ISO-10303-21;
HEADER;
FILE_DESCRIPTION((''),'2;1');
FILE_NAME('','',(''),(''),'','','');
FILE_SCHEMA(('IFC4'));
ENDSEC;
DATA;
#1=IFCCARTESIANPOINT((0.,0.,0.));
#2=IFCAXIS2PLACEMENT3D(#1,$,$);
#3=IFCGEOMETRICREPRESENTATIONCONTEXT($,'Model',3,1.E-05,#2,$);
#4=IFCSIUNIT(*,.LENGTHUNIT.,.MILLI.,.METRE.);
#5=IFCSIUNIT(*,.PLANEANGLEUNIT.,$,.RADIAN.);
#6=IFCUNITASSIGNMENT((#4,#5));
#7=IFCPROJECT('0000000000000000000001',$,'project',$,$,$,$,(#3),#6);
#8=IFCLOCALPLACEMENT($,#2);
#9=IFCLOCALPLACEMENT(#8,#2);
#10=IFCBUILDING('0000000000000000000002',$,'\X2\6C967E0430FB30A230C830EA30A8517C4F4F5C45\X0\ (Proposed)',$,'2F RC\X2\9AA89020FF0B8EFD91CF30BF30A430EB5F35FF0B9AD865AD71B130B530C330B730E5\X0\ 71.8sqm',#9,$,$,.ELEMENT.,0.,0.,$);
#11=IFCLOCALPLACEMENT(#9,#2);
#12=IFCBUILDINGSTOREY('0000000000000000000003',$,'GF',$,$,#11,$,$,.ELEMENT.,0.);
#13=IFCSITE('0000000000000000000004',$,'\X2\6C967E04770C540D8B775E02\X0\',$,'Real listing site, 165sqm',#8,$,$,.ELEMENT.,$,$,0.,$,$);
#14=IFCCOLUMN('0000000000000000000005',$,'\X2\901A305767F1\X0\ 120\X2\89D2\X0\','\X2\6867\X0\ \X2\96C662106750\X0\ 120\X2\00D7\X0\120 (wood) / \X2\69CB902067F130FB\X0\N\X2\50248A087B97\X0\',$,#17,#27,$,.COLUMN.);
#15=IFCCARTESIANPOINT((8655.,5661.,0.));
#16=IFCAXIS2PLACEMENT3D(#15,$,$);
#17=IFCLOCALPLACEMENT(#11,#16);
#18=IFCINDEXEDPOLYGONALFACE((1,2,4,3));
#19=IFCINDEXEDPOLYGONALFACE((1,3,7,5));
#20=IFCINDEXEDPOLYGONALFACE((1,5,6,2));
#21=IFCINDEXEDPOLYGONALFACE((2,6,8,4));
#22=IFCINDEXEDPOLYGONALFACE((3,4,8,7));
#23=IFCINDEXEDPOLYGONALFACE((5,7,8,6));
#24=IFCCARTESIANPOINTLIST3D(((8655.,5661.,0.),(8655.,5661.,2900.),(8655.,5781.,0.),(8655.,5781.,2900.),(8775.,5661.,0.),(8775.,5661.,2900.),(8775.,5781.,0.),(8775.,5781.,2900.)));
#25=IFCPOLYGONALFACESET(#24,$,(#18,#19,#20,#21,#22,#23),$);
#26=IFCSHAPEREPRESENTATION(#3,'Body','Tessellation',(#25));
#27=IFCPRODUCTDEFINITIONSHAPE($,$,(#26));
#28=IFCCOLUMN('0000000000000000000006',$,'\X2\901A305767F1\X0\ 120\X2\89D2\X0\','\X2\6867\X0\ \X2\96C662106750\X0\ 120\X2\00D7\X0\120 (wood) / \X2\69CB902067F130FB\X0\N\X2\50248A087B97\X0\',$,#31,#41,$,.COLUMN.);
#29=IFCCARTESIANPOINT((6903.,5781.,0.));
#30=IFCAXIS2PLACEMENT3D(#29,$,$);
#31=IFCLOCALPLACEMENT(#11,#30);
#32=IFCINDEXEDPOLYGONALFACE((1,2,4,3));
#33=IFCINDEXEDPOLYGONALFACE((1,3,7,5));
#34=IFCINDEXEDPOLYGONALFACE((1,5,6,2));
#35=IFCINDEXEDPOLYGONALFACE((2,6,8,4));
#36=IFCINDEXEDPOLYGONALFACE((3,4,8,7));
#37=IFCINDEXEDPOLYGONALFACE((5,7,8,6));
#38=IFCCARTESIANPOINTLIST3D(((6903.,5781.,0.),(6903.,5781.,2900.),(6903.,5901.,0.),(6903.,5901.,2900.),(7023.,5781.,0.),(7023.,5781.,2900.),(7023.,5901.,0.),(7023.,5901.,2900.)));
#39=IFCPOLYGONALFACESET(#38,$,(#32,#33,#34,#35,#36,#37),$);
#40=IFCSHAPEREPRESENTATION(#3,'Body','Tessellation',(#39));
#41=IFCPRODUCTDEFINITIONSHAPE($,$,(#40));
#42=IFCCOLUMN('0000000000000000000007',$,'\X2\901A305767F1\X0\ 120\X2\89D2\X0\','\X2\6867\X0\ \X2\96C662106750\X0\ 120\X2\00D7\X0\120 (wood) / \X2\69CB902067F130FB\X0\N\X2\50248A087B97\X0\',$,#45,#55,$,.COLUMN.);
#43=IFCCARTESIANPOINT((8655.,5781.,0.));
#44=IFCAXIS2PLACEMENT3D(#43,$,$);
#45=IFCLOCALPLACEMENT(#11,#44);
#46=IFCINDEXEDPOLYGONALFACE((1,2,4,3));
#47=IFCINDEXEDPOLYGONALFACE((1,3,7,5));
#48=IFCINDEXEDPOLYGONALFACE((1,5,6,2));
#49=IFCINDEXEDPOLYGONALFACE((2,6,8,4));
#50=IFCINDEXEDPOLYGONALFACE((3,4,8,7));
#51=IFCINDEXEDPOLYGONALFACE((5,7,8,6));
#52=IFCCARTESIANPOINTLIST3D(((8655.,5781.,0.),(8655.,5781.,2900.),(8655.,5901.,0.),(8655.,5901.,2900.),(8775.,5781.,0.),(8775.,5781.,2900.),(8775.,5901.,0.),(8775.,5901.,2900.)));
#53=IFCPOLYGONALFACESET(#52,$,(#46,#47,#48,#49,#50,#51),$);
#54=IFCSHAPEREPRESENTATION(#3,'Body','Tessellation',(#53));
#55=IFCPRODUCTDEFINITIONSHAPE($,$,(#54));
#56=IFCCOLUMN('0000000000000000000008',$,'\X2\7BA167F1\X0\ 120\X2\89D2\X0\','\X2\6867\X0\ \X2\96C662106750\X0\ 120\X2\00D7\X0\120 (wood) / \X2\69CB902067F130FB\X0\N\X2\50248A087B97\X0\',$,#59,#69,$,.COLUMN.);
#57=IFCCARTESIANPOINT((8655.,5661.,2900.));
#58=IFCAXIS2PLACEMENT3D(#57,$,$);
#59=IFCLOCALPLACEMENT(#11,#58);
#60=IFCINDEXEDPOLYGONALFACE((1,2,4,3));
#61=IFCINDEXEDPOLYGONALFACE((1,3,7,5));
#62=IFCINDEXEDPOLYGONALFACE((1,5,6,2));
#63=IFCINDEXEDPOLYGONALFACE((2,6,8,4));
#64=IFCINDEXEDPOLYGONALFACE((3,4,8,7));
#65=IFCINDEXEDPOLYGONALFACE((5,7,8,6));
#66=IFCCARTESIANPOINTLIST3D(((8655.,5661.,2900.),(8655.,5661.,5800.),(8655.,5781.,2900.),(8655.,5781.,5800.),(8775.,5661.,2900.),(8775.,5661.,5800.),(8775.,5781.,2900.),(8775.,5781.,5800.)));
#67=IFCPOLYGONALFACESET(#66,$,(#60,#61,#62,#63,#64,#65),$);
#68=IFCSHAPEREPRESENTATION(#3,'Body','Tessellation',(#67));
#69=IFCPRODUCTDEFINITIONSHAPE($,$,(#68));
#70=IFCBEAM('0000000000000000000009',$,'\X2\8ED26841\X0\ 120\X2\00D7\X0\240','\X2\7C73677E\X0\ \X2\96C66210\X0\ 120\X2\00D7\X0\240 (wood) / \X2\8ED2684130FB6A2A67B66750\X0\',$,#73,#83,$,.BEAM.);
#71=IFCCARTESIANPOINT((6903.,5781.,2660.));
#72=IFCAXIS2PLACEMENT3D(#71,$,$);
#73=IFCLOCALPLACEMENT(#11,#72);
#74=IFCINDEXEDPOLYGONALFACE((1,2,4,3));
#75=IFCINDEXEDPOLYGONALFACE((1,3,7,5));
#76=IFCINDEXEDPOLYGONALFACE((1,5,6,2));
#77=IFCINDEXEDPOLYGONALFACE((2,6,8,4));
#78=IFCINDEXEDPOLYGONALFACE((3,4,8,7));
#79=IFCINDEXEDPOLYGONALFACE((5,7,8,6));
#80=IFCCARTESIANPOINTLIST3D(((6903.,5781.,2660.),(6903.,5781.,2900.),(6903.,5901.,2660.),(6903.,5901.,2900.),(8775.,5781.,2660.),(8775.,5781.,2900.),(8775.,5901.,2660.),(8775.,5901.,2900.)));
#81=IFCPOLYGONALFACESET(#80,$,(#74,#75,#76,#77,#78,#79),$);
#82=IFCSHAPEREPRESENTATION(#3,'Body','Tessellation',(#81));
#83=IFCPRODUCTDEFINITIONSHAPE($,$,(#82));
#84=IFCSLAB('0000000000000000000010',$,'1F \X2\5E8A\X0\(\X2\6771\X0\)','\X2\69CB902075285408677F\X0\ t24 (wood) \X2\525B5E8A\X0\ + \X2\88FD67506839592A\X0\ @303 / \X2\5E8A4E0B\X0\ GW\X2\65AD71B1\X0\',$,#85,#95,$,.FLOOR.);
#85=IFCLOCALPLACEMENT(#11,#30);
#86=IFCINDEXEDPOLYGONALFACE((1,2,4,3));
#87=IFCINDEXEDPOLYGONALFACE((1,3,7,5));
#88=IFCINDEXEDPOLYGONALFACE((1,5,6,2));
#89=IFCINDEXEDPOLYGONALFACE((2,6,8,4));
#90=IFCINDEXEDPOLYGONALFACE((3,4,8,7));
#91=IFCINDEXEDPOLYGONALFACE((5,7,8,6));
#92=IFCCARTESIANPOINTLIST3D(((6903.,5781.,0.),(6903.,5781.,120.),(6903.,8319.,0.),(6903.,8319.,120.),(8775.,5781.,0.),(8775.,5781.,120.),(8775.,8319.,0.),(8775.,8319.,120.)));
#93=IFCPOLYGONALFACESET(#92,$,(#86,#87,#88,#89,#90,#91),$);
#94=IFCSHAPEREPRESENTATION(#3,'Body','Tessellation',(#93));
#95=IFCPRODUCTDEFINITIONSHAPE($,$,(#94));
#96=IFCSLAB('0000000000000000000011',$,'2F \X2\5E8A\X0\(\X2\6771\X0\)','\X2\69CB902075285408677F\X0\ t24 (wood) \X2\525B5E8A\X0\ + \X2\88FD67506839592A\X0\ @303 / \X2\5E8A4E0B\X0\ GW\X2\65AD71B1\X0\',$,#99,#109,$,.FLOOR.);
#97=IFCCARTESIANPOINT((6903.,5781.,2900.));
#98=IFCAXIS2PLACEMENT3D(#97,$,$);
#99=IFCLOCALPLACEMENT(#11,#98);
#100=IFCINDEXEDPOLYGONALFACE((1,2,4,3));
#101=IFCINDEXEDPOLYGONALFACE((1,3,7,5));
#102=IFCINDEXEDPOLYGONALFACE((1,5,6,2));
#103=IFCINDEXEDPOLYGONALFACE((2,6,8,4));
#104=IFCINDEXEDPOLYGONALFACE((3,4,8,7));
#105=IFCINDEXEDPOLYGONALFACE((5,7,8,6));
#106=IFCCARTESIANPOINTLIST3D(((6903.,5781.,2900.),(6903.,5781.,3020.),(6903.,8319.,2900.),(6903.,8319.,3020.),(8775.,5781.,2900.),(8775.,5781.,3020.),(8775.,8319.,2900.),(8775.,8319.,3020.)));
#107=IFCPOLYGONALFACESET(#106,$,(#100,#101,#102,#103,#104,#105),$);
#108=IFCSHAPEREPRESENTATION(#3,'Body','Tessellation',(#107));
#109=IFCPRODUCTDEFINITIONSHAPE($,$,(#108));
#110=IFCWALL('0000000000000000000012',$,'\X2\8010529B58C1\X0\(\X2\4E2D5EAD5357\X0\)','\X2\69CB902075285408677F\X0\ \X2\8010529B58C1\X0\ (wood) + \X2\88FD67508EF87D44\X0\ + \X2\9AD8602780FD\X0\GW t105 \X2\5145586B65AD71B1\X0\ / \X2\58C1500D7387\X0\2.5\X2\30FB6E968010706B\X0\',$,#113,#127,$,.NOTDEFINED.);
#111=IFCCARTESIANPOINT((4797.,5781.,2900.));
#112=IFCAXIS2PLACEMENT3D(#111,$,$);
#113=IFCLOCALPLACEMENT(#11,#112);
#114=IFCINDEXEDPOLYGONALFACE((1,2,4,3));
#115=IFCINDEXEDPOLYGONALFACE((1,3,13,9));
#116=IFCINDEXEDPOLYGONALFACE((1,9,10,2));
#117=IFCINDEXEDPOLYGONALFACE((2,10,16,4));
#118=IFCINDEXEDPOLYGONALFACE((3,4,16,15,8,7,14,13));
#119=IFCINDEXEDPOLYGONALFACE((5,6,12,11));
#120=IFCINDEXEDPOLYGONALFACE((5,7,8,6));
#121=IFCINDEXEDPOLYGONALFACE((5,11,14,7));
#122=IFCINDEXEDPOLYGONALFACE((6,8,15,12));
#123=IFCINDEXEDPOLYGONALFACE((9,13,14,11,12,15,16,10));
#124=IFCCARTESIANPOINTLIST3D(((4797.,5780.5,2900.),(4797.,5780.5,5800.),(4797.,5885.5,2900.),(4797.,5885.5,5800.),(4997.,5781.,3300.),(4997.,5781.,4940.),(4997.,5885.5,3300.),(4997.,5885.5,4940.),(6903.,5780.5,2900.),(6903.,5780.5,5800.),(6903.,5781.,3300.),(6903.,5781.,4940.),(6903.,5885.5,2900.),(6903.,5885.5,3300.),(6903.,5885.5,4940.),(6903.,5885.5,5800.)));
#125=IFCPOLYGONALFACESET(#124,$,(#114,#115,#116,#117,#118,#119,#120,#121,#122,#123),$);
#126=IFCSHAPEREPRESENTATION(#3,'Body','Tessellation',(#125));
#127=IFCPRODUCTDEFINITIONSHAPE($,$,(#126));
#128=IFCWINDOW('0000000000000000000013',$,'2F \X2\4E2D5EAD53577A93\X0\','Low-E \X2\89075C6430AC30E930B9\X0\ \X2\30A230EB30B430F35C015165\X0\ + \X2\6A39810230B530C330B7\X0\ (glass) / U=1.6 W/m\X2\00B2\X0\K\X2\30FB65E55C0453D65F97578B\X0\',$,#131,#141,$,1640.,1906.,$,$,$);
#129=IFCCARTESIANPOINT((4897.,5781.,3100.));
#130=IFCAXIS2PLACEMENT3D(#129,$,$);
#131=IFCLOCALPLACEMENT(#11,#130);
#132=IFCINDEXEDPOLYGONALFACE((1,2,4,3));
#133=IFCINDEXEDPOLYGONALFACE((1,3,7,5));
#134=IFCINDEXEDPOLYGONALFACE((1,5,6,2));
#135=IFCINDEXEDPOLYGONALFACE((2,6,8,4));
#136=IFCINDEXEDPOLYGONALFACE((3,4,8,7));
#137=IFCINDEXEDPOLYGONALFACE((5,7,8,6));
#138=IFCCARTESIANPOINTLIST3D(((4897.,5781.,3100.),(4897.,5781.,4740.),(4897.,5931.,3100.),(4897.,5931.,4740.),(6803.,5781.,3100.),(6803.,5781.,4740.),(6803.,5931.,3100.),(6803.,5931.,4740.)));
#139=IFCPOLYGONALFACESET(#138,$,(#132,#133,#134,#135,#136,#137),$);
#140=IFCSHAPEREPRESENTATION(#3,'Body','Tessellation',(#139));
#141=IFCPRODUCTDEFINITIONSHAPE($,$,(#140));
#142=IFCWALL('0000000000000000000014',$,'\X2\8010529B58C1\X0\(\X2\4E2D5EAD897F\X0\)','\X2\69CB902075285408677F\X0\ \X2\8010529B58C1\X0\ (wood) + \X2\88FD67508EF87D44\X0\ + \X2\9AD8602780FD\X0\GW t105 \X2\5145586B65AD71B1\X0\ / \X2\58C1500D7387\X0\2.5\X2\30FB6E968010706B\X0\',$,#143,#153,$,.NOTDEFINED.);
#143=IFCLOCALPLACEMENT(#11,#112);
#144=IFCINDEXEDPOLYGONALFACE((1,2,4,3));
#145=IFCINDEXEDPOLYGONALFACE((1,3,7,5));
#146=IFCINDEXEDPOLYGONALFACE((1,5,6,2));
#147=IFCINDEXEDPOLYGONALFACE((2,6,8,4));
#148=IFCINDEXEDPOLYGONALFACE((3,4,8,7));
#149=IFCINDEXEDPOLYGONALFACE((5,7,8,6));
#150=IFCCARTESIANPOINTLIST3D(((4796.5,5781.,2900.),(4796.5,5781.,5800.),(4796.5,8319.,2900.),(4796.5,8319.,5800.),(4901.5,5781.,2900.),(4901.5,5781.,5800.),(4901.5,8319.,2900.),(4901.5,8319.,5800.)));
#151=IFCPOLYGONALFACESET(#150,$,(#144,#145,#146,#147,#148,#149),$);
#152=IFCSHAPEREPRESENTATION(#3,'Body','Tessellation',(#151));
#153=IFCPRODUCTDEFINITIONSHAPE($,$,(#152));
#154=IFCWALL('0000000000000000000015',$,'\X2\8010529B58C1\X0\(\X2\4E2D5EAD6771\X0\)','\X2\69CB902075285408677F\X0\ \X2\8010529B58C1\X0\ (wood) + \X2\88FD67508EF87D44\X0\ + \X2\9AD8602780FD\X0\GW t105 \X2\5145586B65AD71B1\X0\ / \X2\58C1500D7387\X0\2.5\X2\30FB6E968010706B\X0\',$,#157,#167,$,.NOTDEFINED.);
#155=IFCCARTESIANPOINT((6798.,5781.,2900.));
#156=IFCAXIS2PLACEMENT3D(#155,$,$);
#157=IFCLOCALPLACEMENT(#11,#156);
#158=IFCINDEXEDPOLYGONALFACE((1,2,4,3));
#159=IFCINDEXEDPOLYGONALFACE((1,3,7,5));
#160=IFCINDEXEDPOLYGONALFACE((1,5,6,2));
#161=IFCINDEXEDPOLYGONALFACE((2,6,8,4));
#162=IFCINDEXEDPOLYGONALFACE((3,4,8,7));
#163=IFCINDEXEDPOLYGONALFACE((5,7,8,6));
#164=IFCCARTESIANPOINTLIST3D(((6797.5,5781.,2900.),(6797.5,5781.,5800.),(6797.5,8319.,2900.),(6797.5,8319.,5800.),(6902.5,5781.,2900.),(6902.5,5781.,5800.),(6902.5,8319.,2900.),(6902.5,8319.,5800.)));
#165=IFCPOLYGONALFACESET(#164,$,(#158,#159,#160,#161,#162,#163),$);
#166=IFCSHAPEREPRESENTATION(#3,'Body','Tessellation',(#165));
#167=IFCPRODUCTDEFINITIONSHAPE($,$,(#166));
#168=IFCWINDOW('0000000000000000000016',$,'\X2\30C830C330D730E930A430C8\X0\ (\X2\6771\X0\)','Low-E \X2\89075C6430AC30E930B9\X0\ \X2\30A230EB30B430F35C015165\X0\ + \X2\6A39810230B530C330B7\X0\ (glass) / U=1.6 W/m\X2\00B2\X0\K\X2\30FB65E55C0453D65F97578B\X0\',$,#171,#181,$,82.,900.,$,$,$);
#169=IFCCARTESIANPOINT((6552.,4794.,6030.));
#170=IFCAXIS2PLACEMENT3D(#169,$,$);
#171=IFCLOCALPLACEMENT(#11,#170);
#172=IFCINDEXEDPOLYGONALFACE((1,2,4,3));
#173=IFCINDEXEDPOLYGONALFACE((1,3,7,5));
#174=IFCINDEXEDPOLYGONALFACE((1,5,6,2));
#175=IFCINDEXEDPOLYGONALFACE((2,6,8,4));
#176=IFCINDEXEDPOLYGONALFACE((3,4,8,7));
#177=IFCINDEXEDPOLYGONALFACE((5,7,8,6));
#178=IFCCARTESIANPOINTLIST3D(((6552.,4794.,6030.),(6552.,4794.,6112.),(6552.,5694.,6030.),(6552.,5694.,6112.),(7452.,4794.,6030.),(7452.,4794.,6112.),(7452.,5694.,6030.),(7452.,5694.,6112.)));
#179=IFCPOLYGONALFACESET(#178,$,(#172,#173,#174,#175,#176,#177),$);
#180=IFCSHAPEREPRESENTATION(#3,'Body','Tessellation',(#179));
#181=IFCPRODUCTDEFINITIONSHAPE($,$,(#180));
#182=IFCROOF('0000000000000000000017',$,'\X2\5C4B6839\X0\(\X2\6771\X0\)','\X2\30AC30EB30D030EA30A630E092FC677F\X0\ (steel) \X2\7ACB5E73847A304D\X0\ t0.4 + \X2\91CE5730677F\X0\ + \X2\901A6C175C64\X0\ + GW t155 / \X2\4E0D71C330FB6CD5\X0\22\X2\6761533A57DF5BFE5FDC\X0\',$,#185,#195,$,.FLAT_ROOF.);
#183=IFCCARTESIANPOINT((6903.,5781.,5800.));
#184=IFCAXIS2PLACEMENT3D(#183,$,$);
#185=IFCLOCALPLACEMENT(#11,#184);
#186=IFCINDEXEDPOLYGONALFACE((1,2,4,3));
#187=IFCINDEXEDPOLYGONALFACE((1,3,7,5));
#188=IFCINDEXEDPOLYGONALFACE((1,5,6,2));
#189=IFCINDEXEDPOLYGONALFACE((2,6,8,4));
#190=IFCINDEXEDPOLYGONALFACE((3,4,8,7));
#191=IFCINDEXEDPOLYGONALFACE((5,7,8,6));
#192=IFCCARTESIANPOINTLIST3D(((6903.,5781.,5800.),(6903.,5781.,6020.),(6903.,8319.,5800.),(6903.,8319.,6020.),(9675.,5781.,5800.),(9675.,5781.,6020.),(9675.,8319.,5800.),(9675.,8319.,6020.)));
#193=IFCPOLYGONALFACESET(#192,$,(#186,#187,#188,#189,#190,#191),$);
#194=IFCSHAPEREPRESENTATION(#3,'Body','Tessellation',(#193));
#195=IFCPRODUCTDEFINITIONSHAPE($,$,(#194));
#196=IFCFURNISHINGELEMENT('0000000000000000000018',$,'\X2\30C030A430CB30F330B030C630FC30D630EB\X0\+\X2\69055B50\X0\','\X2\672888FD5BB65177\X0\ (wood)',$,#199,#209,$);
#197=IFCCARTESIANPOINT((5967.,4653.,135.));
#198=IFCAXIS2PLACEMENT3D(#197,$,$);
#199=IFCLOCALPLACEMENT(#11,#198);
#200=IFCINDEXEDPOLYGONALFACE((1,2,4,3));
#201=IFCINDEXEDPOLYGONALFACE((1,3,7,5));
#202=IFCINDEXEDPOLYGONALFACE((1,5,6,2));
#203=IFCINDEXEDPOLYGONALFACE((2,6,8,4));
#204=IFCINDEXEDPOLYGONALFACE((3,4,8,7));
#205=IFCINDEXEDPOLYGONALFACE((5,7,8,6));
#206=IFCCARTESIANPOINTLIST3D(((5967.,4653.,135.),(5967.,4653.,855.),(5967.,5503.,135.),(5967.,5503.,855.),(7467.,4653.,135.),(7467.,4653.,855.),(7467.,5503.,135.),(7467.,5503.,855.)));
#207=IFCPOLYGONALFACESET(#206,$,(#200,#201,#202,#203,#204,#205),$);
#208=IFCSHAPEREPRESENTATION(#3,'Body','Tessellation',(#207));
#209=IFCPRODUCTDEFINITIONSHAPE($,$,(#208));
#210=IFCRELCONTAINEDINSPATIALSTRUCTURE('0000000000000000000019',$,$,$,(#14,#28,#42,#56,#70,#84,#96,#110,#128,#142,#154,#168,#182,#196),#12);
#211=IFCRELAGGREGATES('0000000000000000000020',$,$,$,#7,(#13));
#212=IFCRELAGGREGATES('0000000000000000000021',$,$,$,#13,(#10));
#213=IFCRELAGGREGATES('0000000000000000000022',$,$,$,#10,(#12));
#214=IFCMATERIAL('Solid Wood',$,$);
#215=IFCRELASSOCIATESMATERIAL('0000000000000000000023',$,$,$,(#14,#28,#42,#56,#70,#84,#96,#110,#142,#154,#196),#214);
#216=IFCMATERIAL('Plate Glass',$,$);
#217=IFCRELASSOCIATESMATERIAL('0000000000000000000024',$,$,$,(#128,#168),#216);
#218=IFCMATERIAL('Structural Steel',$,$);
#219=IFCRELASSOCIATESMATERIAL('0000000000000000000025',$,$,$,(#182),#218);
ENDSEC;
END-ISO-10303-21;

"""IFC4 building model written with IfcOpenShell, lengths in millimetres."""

from ifc_helpers import new_model, si_unit, frame, frame_2d, origin, place, context, project, spatial, rectangle, extrude, material, element, fill, save


model = new_model("IFC4")

# Units and contexts
model_context = context("Model", 3, precision=1e-05, world=origin())
ifc_project = project(units=[si_unit("LENGTHUNIT", "METRE", prefix="MILLI"), si_unit("PLANEANGLEUNIT", "RADIAN")], contexts=[model_context])

# Site, building, storey
site_placement = place(None, origin())
site = spatial("IfcSite", under=ifc_project, at=site_placement, Name="沖縄県名護市", ObjectType="Real listing site, 165sqm", CompositionType="ELEMENT", RefElevation=0.0)
building_placement = place(site_placement, origin())
building = spatial("IfcBuilding", under=site, at=building_placement, Name="沖縄・アトリエ兼住居 (Proposed)", ObjectType="2F RC骨造＋軽量タイル張＋高断熱サッシュ 71.8sqm", CompositionType="ELEMENT", ElevationOfRefHeight=0.0, ElevationOfTerrain=0.0)
storey_placement = place(building_placement, origin())
storey = spatial("IfcBuildingStorey", under=building, at=storey_placement, Name="GF", CompositionType="ELEMENT", Elevation=0.0)

# Columns
ifc_material_1 = material(Name="Solid Wood")
column_1_placement = place(storey_placement, frame((8655.0, 5661.0, 0.0)))
element("IfcColumn", 1, at=column_1_placement, inside=storey, material=ifc_material_1, Name="通し柱 120角", Description="桧 集成材 120×120 (wood) / 構造柱・N値計算", PredefinedType="COLUMN", context=model_context, shape_type="SweptSolid", body=[
    extrude(rectangle(XDim=120.0, YDim=120.0, at=frame_2d((60.0, 60.0))), frame((8655.0, 5661.0, 0.0)), (0.0, 0.0, 1.0), 2900.0),
])
column_2_placement = place(storey_placement, frame((6903.0, 5781.0, 0.0)))
element("IfcColumn", 2, at=column_2_placement, inside=storey, material=ifc_material_1, Name="通し柱 120角", Description="桧 集成材 120×120 (wood) / 構造柱・N値計算", PredefinedType="COLUMN", context=model_context, shape_type="SweptSolid", body=[
    extrude(rectangle(XDim=120.0, YDim=120.0, at=frame_2d((60.0, 60.0))), frame((6903.0, 5781.0, 0.0)), (0.0, 0.0, 1.0), 2900.0),
])
column_3_placement = place(storey_placement, frame((8655.0, 5781.0, 0.0)))
element("IfcColumn", 3, at=column_3_placement, inside=storey, material=ifc_material_1, Name="通し柱 120角", Description="桧 集成材 120×120 (wood) / 構造柱・N値計算", PredefinedType="COLUMN", context=model_context, shape_type="SweptSolid", body=[
    extrude(rectangle(XDim=120.0, YDim=120.0, at=frame_2d((60.0, 60.0))), frame((8655.0, 5781.0, 0.0)), (0.0, 0.0, 1.0), 2900.0),
])
column_4_placement = place(storey_placement, frame((8655.0, 5661.0, 2900.0)))
element("IfcColumn", 4, at=column_4_placement, inside=storey, material=ifc_material_1, Name="管柱 120角", Description="桧 集成材 120×120 (wood) / 構造柱・N値計算", PredefinedType="COLUMN", context=model_context, shape_type="SweptSolid", body=[
    extrude(rectangle(XDim=120.0, YDim=120.0, at=frame_2d((60.0, 60.0))), frame((8655.0, 5661.0, 2900.0)), (0.0, 0.0, 1.0), 2900.0),
])

# Beam
beam_1_placement = place(storey_placement, frame((6903.0, 5781.0, 2660.0)))
element("IfcBeam", 5, at=beam_1_placement, inside=storey, material=ifc_material_1, Name="軒桁 120×240", Description="米松 集成 120×240 (wood) / 軒桁・横架材", PredefinedType="BEAM", context=model_context, shape_type="SweptSolid", body=[
    extrude(rectangle(XDim=1872.0, YDim=120.0, at=frame_2d((936.0, 60.0))), frame((6903.0, 5781.0, 2660.0)), (0.0, 0.0, 1.0), 240.0),
])

# Slabs
slab_1_placement = place(storey_placement, frame((6903.0, 5781.0, 0.0)))
element("IfcSlab", 6, at=slab_1_placement, inside=storey, material=ifc_material_1, Name="1F 床(東)", Description="構造用合板 t24 (wood) 剛床 + 製材根太 @303 / 床下 GW断熱", PredefinedType="FLOOR", context=model_context, shape_type="SweptSolid", body=[
    extrude(rectangle(XDim=1872.0, YDim=2538.0, at=frame_2d((936.0, 1269.0))), frame((6903.0, 5781.0, 0.0)), (0.0, 0.0, 1.0), 120.0),
])
slab_2_placement = place(storey_placement, frame((6903.0, 5781.0, 2900.0)))
element("IfcSlab", 7, at=slab_2_placement, inside=storey, material=ifc_material_1, Name="2F 床(東)", Description="構造用合板 t24 (wood) 剛床 + 製材根太 @303 / 床下 GW断熱", PredefinedType="FLOOR", context=model_context, shape_type="SweptSolid", body=[
    extrude(rectangle(XDim=1872.0, YDim=2538.0, at=frame_2d((936.0, 1269.0))), frame((6903.0, 5781.0, 2900.0)), (0.0, 0.0, 1.0), 120.0),
])

# Wall, opening, window
wall_1_placement = place(storey_placement, frame((4797.0, 5781.0, 2900.0)))
wall_1 = element("IfcWall", 8, at=wall_1_placement, inside=storey, material=ifc_material_1, Name="耐力壁(中庭南)", Description="構造用合板 耐力壁 (wood) + 製材軸組 + 高性能GW t105 充填断熱 / 壁倍率2.5・準耐火", PredefinedType="NOTDEFINED", context=model_context, shape_type="SweptSolid", body=[
    extrude(rectangle(XDim=2106.0, YDim=105.0, at=frame_2d((1053.0, 52.0))), frame((4797.0, 5781.0, 2900.0)), (0.0, 0.0, 1.0), 2900.0),
])
opening_placement = place(storey_placement, frame((4897.0, 5781.0, 3100.0)))
opening = element("IfcOpeningElement", 9, at=opening_placement, cuts=wall_1, PredefinedType="NOTDEFINED", context=model_context, shape_type="SweptSolid", body=[
    extrude(rectangle(XDim=1906.0, YDim=150.0, at=frame_2d((953.0, 75.0))), frame((4897.0, 5781.0, 3100.0)), (0.0, 0.0, 1.0), 1640.0),
])
ifc_material_2 = material(Name="Plate Glass")
window_1_placement = place(storey_placement, frame((4897.0, 5781.0, 3100.0)))
window_1 = element("IfcWindow", 10, at=window_1_placement, inside=storey, material=ifc_material_2, Name="2F 中庭南窓", Description="Low-E 複層ガラス アルゴン封入 + 樹脂サッシ (glass) / U=1.6 W/m²K・日射取得型", OverallHeight=1640.0, OverallWidth=1906.0, context=model_context, shape_type="SweptSolid", body=[
    extrude(rectangle(XDim=1906.0, YDim=150.0, at=frame_2d((953.0, 75.0))), frame((4897.0, 5781.0, 3100.0)), (0.0, 0.0, 1.0), 1640.0),
])
fill(opening, window_1)

# Walls
wall_2_placement = place(storey_placement, frame((4797.0, 5781.0, 2900.0)))
element("IfcWall", 11, at=wall_2_placement, inside=storey, material=ifc_material_1, Name="耐力壁(中庭西)", Description="構造用合板 耐力壁 (wood) + 製材軸組 + 高性能GW t105 充填断熱 / 壁倍率2.5・準耐火", PredefinedType="NOTDEFINED", context=model_context, shape_type="SweptSolid", body=[
    extrude(rectangle(XDim=105.0, YDim=2538.0, at=frame_2d((52.0, 1269.0))), frame((4797.0, 5781.0, 2900.0)), (0.0, 0.0, 1.0), 2900.0),
])
wall_3_placement = place(storey_placement, frame((6798.0, 5781.0, 2900.0)))
element("IfcWall", 12, at=wall_3_placement, inside=storey, material=ifc_material_1, Name="耐力壁(中庭東)", Description="構造用合板 耐力壁 (wood) + 製材軸組 + 高性能GW t105 充填断熱 / 壁倍率2.5・準耐火", PredefinedType="NOTDEFINED", context=model_context, shape_type="SweptSolid", body=[
    extrude(rectangle(XDim=105.0, YDim=2538.0, at=frame_2d((52.0, 1269.0))), frame((6798.0, 5781.0, 2900.0)), (0.0, 0.0, 1.0), 2900.0),
])

# Window
window_2_placement = place(storey_placement, frame((6552.0, 4794.0, 6030.0)))
element("IfcWindow", 13, at=window_2_placement, inside=storey, material=ifc_material_2, Name="トップライト (東)", Description="Low-E 複層ガラス アルゴン封入 + 樹脂サッシ (glass) / U=1.6 W/m²K・日射取得型", OverallHeight=82.0, OverallWidth=900.0, context=model_context, shape_type="SweptSolid", body=[
    extrude(rectangle(XDim=900.0, YDim=900.0, at=frame_2d((450.0, 450.0))), frame((6552.0, 4794.0, 6030.0)), (0.0, 0.0, 1.0), 82.0),
])

# Roof
ifc_material_3 = material(Name="Structural Steel")
for number, where, name in (
    (14, (6903.0, 5781.0, 5800.0), "屋根(東)"),
):
    element("IfcRoof", number, at=place(storey_placement, frame(where)), inside=storey, material=ifc_material_3, Name=name, Description="ガルバリウム鋼板 (steel) 立平葺き t0.4 + 野地板 + 通気層 + GW t155 / 不燃・法22条区域対応", PredefinedType="FLAT_ROOF", context=model_context, shape_type="SweptSolid", body=[
        extrude(rectangle(XDim=2772.0, YDim=2538.0, at=frame_2d((1386.0, 1269.0))), frame((6903.0, 5781.0, 5800.0)), (0.0, 0.0, 1.0), 220.0),
    ])

# Furnishing element
furnishing_1_placement = place(storey_placement, frame((5967.0, 4653.0, 135.0)))
element("IfcFurnishingElement", 15, at=furnishing_1_placement, inside=storey, material=ifc_material_1, Name="ダイニングテーブル+椅子", Description="木製家具 (wood)", context=model_context, shape_type="SweptSolid", body=[
    extrude(rectangle(XDim=1500.0, YDim=850.0, at=frame_2d((750.0, 425.0))), frame((5967.0, 4653.0, 135.0)), (0.0, 0.0, 1.0), 720.0),
])

save(model, "model.ifc")
